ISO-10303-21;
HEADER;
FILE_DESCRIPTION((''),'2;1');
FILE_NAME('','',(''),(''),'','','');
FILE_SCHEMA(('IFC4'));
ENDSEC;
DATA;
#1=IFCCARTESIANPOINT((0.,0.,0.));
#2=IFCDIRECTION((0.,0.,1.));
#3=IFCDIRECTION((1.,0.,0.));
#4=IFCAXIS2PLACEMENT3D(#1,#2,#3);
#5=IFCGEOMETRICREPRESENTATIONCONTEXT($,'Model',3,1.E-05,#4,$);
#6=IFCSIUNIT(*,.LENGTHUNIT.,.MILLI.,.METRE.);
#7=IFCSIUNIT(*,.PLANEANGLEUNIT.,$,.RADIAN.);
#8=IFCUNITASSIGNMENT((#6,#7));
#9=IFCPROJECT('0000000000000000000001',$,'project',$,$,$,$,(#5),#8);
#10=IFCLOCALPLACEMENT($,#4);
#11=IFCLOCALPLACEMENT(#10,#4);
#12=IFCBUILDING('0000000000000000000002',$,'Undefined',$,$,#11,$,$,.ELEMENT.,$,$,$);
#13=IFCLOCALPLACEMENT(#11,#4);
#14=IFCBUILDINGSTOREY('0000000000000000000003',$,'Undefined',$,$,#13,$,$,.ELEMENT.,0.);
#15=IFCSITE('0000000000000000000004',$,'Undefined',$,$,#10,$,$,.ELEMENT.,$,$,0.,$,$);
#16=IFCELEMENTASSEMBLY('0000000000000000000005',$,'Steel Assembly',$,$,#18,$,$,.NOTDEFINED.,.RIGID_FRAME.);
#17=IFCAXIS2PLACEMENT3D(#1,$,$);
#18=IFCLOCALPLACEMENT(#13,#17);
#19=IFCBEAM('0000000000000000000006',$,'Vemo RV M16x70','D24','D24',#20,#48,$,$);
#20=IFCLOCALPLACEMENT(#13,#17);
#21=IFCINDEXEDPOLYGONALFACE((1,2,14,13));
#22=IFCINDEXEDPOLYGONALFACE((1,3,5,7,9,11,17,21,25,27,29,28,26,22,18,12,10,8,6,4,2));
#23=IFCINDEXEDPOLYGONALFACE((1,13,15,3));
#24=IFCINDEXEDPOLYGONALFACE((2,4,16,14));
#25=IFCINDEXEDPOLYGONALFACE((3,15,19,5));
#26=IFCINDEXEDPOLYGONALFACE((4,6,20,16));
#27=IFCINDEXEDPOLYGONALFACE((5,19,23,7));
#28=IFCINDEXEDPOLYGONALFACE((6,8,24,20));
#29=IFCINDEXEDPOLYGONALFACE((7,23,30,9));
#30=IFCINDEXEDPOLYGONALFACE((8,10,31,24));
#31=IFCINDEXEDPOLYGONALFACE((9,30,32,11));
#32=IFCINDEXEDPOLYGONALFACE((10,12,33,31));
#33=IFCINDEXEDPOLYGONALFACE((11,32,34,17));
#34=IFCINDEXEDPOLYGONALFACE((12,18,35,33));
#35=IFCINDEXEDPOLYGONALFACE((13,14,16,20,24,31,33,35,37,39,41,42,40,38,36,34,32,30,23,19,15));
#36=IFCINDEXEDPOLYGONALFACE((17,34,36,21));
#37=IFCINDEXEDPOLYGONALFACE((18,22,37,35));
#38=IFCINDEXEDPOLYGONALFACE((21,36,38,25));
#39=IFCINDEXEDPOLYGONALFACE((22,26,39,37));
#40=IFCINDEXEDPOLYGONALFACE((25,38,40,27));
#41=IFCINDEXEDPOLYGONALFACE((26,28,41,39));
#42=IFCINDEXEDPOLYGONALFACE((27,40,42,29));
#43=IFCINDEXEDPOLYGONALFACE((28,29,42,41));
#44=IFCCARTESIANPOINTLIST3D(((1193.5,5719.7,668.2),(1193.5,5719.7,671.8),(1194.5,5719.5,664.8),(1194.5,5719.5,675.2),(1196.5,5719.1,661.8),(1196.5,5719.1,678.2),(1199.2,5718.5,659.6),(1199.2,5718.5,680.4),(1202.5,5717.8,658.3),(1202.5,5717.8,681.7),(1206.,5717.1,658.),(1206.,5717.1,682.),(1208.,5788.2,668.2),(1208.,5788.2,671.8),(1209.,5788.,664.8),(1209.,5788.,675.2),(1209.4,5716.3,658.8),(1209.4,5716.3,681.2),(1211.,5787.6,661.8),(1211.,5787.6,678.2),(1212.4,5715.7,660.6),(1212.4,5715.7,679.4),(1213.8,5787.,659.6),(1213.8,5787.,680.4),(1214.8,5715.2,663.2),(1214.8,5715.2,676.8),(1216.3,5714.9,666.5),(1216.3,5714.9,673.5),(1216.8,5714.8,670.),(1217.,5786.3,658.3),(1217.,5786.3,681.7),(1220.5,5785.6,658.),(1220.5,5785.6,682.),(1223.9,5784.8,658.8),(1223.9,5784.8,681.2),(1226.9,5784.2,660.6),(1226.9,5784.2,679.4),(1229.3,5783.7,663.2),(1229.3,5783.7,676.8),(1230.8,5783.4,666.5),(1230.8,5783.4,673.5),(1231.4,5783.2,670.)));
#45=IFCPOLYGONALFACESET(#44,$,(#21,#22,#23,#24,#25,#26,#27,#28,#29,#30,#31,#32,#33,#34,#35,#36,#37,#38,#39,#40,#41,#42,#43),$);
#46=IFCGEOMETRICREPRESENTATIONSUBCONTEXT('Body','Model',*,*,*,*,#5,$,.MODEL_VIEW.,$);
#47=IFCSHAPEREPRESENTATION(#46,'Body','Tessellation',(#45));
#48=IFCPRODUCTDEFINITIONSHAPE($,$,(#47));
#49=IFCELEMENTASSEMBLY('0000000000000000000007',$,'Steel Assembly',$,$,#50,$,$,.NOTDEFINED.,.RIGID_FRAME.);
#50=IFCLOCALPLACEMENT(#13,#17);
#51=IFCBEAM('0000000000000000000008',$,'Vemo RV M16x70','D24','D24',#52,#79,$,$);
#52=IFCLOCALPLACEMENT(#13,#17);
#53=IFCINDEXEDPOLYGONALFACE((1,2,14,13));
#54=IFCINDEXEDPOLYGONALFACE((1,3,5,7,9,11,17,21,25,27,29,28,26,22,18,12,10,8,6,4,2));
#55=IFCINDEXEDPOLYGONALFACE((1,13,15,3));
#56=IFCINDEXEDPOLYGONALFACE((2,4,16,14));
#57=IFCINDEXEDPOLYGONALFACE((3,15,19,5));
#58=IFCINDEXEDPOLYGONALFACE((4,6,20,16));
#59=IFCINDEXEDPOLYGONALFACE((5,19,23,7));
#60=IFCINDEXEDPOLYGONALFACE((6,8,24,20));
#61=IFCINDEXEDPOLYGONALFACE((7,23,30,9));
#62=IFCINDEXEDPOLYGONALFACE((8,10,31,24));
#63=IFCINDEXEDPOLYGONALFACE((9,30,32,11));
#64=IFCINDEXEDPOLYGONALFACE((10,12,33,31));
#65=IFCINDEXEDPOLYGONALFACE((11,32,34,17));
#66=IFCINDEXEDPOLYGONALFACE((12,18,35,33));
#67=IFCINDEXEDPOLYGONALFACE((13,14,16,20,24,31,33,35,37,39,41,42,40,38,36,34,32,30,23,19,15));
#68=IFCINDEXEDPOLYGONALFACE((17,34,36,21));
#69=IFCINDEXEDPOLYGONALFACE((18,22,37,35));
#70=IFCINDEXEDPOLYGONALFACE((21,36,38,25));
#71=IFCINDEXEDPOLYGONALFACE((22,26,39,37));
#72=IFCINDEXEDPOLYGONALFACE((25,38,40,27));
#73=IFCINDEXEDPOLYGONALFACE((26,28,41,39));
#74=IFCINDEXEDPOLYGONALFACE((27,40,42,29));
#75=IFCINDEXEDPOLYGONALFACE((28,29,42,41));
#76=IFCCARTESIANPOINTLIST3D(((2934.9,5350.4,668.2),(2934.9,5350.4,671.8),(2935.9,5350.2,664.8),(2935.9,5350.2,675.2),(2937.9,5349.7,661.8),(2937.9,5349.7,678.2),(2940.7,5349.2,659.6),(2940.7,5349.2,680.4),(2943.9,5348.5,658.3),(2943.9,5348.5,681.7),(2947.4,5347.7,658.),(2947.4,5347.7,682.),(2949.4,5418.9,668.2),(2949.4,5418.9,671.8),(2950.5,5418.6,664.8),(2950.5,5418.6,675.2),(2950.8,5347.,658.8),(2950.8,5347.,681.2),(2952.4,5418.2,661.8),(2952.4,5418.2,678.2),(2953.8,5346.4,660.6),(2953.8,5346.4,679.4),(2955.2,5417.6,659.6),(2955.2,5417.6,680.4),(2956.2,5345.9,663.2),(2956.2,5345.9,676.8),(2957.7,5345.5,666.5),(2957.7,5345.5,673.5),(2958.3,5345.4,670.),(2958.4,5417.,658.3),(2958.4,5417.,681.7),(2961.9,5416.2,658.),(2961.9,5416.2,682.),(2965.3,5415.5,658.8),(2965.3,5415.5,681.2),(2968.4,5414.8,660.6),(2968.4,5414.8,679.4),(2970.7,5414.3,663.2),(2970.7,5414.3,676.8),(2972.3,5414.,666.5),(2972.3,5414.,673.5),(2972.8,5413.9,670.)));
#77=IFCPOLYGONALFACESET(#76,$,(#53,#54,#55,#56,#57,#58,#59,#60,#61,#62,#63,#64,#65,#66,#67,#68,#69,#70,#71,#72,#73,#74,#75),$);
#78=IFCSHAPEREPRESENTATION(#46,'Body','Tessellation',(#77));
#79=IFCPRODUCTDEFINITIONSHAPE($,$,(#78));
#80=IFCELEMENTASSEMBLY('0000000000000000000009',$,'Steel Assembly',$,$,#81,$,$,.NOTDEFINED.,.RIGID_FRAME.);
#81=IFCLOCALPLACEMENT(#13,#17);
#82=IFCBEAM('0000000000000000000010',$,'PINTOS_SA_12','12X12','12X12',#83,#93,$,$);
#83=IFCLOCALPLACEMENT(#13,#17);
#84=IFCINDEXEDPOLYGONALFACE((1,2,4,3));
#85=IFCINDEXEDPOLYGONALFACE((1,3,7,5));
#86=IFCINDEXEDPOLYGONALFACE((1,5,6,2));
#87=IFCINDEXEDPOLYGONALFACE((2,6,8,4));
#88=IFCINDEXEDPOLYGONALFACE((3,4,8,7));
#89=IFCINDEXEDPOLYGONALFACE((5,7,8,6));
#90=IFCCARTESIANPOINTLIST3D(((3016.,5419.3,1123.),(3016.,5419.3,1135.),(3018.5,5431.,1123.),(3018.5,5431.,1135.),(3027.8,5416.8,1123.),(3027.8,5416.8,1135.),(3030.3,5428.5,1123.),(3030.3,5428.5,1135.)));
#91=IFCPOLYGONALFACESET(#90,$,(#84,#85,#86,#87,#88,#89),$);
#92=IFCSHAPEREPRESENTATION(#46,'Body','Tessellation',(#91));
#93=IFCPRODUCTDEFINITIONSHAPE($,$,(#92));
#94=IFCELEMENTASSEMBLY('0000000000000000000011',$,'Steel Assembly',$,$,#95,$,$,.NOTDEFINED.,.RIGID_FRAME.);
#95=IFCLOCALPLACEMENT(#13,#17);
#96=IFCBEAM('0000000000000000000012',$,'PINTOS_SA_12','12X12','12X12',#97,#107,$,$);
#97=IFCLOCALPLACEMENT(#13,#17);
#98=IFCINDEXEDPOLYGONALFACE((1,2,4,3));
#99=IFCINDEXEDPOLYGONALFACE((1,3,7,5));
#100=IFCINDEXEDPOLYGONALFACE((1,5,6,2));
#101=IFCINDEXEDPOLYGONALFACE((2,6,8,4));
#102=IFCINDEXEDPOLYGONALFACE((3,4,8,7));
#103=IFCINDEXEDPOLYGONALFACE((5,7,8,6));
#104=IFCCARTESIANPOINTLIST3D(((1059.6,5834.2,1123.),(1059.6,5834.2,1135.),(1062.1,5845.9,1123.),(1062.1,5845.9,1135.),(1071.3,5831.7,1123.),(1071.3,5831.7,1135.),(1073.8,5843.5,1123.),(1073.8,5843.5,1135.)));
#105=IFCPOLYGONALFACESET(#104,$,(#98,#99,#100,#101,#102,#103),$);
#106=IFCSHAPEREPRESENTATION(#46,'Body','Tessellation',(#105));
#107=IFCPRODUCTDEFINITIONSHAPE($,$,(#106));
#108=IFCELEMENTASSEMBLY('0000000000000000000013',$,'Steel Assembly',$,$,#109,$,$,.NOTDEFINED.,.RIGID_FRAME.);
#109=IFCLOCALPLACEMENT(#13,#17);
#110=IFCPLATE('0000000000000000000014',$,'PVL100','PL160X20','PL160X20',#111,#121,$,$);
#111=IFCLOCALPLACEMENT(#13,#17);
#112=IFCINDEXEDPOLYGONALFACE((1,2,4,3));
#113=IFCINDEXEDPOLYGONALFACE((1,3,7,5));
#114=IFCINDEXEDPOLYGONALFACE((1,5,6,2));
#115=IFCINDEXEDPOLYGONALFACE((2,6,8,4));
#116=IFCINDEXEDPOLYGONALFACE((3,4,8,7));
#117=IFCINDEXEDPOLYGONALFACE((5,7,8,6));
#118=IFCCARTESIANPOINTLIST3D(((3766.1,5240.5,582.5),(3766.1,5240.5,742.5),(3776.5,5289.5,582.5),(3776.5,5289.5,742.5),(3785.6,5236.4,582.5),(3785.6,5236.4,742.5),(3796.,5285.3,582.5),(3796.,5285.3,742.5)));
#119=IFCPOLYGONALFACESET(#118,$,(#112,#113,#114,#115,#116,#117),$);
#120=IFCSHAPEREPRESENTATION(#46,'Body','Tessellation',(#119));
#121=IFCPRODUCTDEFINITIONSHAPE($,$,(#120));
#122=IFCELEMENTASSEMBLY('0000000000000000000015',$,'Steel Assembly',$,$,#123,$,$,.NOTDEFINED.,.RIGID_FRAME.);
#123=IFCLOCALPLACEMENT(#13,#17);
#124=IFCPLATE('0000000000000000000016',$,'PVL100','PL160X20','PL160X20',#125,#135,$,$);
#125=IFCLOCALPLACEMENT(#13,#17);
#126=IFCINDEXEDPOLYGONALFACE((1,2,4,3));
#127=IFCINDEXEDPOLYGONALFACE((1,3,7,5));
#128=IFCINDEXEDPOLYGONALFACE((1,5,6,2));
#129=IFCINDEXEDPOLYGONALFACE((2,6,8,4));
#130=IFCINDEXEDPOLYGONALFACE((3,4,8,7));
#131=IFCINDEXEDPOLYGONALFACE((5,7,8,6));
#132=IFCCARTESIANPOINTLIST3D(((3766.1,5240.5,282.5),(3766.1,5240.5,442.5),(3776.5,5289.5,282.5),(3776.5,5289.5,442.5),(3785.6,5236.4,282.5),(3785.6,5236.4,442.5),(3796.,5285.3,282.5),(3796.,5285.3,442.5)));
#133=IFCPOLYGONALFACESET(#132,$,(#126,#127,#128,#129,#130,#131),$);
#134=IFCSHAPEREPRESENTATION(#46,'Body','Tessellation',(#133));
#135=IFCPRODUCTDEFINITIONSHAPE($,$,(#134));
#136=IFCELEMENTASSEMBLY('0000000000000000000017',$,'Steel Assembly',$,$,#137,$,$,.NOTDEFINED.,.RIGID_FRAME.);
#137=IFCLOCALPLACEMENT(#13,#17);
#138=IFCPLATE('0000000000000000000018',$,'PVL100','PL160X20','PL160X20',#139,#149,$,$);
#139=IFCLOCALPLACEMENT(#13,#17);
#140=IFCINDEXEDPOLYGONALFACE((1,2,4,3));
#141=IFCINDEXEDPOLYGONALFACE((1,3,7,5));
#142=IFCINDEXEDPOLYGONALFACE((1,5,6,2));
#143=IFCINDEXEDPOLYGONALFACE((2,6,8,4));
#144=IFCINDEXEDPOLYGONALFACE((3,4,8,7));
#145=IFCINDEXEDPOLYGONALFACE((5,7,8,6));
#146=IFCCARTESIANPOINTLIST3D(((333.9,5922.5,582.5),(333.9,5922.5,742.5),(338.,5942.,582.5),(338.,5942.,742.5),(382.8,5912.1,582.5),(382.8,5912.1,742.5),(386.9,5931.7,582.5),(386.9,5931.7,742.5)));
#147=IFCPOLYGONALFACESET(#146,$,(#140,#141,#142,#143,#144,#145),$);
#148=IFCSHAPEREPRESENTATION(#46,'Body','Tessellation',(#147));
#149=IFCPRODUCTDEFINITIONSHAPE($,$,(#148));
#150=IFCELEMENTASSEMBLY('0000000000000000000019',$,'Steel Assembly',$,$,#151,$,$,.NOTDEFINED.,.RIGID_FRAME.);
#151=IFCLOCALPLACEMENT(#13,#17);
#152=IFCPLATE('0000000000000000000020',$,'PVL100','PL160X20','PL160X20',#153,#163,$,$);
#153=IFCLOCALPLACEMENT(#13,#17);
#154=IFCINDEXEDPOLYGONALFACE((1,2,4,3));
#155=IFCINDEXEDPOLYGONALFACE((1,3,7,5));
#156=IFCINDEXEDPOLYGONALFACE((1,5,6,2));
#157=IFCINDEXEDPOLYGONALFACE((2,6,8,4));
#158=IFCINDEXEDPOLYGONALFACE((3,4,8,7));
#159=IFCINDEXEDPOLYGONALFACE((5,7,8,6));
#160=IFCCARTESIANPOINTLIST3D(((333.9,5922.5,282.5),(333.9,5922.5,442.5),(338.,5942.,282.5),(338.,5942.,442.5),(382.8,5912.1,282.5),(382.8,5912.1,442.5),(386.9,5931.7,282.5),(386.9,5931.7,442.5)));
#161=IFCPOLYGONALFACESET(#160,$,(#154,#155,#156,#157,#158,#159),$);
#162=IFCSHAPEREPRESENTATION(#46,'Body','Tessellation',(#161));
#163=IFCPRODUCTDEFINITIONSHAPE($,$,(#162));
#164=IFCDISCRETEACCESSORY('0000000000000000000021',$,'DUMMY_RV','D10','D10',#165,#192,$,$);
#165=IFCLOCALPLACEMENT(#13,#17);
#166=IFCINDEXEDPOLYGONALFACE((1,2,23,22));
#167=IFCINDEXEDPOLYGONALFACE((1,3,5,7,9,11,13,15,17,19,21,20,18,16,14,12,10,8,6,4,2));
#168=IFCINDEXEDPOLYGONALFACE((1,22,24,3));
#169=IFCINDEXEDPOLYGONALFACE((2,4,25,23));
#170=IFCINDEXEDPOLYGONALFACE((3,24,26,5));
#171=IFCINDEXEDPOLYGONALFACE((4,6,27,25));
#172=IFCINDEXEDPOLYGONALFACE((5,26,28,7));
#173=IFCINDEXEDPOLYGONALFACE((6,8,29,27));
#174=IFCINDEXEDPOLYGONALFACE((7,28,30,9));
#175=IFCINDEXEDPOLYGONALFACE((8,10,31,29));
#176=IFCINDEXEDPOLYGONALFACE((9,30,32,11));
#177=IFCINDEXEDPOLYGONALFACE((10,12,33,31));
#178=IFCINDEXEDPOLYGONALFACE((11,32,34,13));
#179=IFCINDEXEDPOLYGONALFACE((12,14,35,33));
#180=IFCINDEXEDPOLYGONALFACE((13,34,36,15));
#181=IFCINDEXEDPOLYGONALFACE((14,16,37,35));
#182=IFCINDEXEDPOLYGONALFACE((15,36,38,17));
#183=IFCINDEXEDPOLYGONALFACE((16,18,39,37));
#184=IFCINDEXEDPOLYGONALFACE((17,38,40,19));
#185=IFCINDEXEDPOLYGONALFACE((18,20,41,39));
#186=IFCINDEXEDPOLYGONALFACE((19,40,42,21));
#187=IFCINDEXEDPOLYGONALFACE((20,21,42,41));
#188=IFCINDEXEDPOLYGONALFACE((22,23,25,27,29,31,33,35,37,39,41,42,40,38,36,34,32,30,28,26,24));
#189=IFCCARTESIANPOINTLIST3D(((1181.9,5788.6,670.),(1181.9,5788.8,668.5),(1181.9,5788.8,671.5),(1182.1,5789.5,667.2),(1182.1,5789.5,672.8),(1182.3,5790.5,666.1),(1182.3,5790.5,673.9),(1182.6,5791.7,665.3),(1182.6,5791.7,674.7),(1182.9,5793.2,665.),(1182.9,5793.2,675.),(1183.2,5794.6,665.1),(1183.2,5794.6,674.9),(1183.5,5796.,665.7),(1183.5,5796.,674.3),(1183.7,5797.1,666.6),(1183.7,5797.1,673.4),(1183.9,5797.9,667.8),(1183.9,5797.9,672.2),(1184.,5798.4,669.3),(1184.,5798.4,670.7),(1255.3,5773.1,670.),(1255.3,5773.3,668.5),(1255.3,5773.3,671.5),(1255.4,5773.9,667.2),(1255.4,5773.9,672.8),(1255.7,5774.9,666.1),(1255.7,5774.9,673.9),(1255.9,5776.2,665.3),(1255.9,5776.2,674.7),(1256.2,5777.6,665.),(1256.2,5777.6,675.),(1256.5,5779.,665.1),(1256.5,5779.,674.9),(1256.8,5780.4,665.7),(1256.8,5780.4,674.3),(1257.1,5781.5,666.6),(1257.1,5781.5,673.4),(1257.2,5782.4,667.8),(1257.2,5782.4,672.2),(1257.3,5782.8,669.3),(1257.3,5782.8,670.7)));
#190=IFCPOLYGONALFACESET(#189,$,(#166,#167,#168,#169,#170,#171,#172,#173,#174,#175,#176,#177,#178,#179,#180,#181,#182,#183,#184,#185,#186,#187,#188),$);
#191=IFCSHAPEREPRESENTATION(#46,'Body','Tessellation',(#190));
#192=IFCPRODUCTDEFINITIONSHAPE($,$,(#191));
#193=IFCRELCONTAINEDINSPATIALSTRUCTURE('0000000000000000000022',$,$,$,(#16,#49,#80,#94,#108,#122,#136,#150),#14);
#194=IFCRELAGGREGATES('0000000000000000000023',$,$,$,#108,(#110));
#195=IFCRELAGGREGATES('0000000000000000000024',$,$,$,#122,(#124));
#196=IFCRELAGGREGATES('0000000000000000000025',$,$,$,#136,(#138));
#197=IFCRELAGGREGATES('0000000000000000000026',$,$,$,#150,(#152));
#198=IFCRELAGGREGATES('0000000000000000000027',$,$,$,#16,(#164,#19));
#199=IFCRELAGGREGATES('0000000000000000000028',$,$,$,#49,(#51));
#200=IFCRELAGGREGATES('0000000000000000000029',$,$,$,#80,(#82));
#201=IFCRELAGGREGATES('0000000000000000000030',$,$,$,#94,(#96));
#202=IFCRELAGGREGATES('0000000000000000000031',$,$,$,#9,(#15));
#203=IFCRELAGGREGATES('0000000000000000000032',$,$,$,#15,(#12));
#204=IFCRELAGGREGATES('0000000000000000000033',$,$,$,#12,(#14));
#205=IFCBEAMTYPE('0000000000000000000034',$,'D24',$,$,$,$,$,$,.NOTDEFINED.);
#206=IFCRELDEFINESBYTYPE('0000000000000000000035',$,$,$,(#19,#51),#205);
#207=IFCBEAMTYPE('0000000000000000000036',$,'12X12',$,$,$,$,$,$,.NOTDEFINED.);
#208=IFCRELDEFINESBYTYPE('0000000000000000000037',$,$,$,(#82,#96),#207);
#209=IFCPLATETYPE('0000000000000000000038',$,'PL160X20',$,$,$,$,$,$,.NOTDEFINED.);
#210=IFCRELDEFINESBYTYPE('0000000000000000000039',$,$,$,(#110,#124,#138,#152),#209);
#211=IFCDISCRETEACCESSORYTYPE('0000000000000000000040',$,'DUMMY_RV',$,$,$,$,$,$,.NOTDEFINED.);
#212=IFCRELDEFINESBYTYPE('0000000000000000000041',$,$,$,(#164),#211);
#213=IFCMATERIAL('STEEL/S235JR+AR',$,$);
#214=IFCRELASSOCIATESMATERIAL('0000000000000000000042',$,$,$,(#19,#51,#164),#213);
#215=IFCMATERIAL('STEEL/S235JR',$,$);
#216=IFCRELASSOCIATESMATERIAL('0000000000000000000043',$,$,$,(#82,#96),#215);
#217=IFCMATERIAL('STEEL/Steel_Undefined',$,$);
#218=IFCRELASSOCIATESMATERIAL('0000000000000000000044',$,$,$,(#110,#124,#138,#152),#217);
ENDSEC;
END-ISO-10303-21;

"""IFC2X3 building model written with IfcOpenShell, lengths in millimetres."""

from ifc_helpers import new_model, si_unit, frame, origin_with_axes, origin_2d_with_axis, place, context, subcontext, project, spatial, polyline, rectangle, circle, outline, extrude, material, type_object, element, aggregate, save


model = new_model("IFC2X3")

# Units and contexts
model_context = context("Model", 3, precision=1e-05, world=origin_with_axes())
body_context = subcontext(model_context, "Body", "Model", "MODEL_VIEW")
ifc_project = project(units=[si_unit("LENGTHUNIT", "METRE", prefix="MILLI"), si_unit("PLANEANGLEUNIT", "RADIAN")], contexts=[model_context])

# Site, building, storey
site_placement = place(None, origin_with_axes())
site = spatial("IfcSite", under=ifc_project, at=site_placement, Name="Undefined", CompositionType="ELEMENT", RefElevation=0.0)
building_placement = place(site_placement, origin_with_axes())
building = spatial("IfcBuilding", under=site, at=building_placement, Name="Undefined", CompositionType="ELEMENT")
storey_placement = place(building_placement, origin_with_axes())
storey = spatial("IfcBuildingStorey", under=building, at=storey_placement, Name="Undefined", CompositionType="ELEMENT", Elevation=0.0)

# Element assemblies, beams
assembly_1_placement = place(storey_placement, origin_with_axes())
assembly_1 = element("IfcElementAssembly", 1, at=assembly_1_placement, inside=storey, Name="Steel Assembly", AssemblyPlace="NOTDEFINED", PredefinedType="RIGID_FRAME")
ifc_material_1 = material(Name="STEEL/S235JR+AR")
beam_type_1 = type_object("IfcBeamType", Name="D24", PredefinedType="NOTDEFINED")
beam_1_placement = place(assembly_1_placement, frame((1205.1, 5717.3, 670.0), z_axis=(0.0, 0.0, 1.0), x_axis=(0.207475, 0.97824, 0.0)))
beam_1 = element("IfcBeam", 2, at=beam_1_placement, type_object=beam_type_1, material=ifc_material_1, Name="Vemo RV M16x70", Description="D24", ObjectType="D24", context=body_context, shape_type="SweptSolid", body=[
    extrude(circle(Radius=12.0, at=origin_2d_with_axis()), frame((70.0, 0.0, 0.0), z_axis=(-1.0, 0.0, 0.0), x_axis=(0.0, -1.0, 0.0)), (0.0, 0.0, 1.0), 70.0),
])
assembly_2_placement = place(storey_placement, origin_with_axes())
assembly_2 = element("IfcElementAssembly", 3, at=assembly_2_placement, inside=storey, Name="Steel Assembly", AssemblyPlace="NOTDEFINED", PredefinedType="RIGID_FRAME")
beam_2_placement = place(assembly_2_placement, frame((2946.5, 5347.9, 670.0), z_axis=(0.0, 0.0, 1.0), x_axis=(0.207475, 0.97824, 0.0)))
beam_2 = element("IfcBeam", 4, at=beam_2_placement, type_object=beam_type_1, material=ifc_material_1, Name="Vemo RV M16x70", Description="D24", ObjectType="D24", context=body_context, shape_type="SweptSolid", body=[
    extrude(circle(Radius=12.0, at=origin_2d_with_axis()), frame((70.0, 0.0, 0.0), z_axis=(-1.0, 0.0, 0.0), x_axis=(0.0, -1.0, 0.0)), (0.0, 0.0, 1.0), 70.0),
])
assembly_3_placement = place(storey_placement, origin_with_axes())
assembly_3 = element("IfcElementAssembly", 5, at=assembly_3_placement, inside=storey, Name="Steel Assembly", AssemblyPlace="NOTDEFINED", PredefinedType="RIGID_FRAME")
ifc_material_2 = material(Name="STEEL/S235JR")
beam_type_2 = type_object("IfcBeamType", Name="12X12", PredefinedType="NOTDEFINED")
beam_3_placement = place(assembly_3_placement, frame((3029.0, 5422.6, 1129.0), z_axis=(0.0, 0.0, 1.0), x_axis=(-0.97824, 0.207475, 0.0)))
beam_3 = element("IfcBeam", 6, at=beam_3_placement, type_object=beam_type_2, material=ifc_material_2, Name="PINTOS_SA_12", Description="12X12", ObjectType="12X12", context=body_context, shape_type="SweptSolid", body=[
    extrude(rectangle(XDim=12.0, YDim=12.0, at=origin_2d_with_axis()), frame((12.0, 0.0, 0.0), z_axis=(-1.0, 0.0, 0.0), x_axis=(0.0, -1.0, 0.0)), (0.0, 0.0, 1.0), 12.0),
])
assembly_4_placement = place(storey_placement, origin_with_axes())
assembly_4 = element("IfcElementAssembly", 7, at=assembly_4_placement, inside=storey, Name="Steel Assembly", AssemblyPlace="NOTDEFINED", PredefinedType="RIGID_FRAME")
beam_4_placement = place(assembly_4_placement, frame((1060.8, 5840.1, 1129.0), z_axis=(0.0, 0.0, 1.0), x_axis=(0.97824, -0.207475, 0.0)))
beam_4 = element("IfcBeam", 8, at=beam_4_placement, type_object=beam_type_2, material=ifc_material_2, Name="PINTOS_SA_12", Description="12X12", ObjectType="12X12", context=body_context, shape_type="SweptSolid", body=[
    extrude(rectangle(XDim=12.0, YDim=12.0, at=origin_2d_with_axis()), frame((12.0, 0.0, 0.0), z_axis=(-1.0, 0.0, 0.0), x_axis=(0.0, -1.0, 0.0)), (0.0, 0.0, 1.0), 12.0),
])

# Element assemblies, plates
assembly_5_placement = place(storey_placement, origin_with_axes())
assembly_5 = element("IfcElementAssembly", 9, at=assembly_5_placement, inside=storey, Name="Steel Assembly", AssemblyPlace="NOTDEFINED", PredefinedType="RIGID_FRAME")
ifc_material_3 = material(Name="STEEL/Steel_Undefined")
plate_type = type_object("IfcPlateType", Name="PL160X20", PredefinedType="NOTDEFINED")
plate_1_placement = place(assembly_5_placement, frame((3796.0, 5285.3, 662.5), z_axis=(0.0, 0.0, -1.0), x_axis=(-0.207475, -0.97824, 0.0)))
plate_1 = element("IfcPlate", 10, at=plate_1_placement, type_object=plate_type, material=ifc_material_3, Name="PVL100", Description="PL160X20", ObjectType="PL160X20", context=body_context, shape_type="SweptSolid", body=[
    extrude(outline(polyline([(0.0, 0.0), (50.0, 0.0), (50.0, 20.0), (0.0, 20.0), (0.0, 0.0)])), frame((0.0, 0.0, -80.0), z_axis=(0.0, 0.0, 1.0), x_axis=(1.0, 0.0, 0.0)), (0.0, 0.0, 1.0), 160.0),
])
assembly_6_placement = place(storey_placement, origin_with_axes())
assembly_6 = element("IfcElementAssembly", 11, at=assembly_6_placement, inside=storey, Name="Steel Assembly", AssemblyPlace="NOTDEFINED", PredefinedType="RIGID_FRAME")
plate_2_placement = place(assembly_6_placement, frame((3796.0, 5285.3, 362.5), z_axis=(0.0, 0.0, -1.0), x_axis=(-0.207475, -0.97824, 0.0)))
plate_2 = element("IfcPlate", 12, at=plate_2_placement, type_object=plate_type, material=ifc_material_3, Name="PVL100", Description="PL160X20", ObjectType="PL160X20", context=body_context, shape_type="SweptSolid", body=[
    extrude(outline(polyline([(0.0, 0.0), (50.0, 0.0), (50.0, 20.0), (0.0, 20.0), (0.0, 0.0)])), frame((0.0, 0.0, -80.0), z_axis=(0.0, 0.0, 1.0), x_axis=(1.0, 0.0, 0.0)), (0.0, 0.0, 1.0), 160.0),
])
assembly_7_placement = place(storey_placement, origin_with_axes())
assembly_7 = element("IfcElementAssembly", 13, at=assembly_7_placement, inside=storey, Name="Steel Assembly", AssemblyPlace="NOTDEFINED", PredefinedType="RIGID_FRAME")
plate_3_placement = place(assembly_7_placement, frame((382.8, 5912.1, 662.5), z_axis=(0.0, 0.0, -1.0), x_axis=(-0.97824, 0.207475, 0.0)))
plate_3 = element("IfcPlate", 14, at=plate_3_placement, type_object=plate_type, material=ifc_material_3, Name="PVL100", Description="PL160X20", ObjectType="PL160X20", context=body_context, shape_type="SweptSolid", body=[
    extrude(outline(polyline([(0.0, 0.0), (50.0, 0.0), (50.0, 20.0), (0.0, 20.0), (0.0, 0.0)])), frame((0.0, 0.0, -80.0), z_axis=(0.0, 0.0, 1.0), x_axis=(1.0, 0.0, 0.0)), (0.0, 0.0, 1.0), 160.0),
])
assembly_8_placement = place(storey_placement, origin_with_axes())
assembly_8 = element("IfcElementAssembly", 15, at=assembly_8_placement, inside=storey, Name="Steel Assembly", AssemblyPlace="NOTDEFINED", PredefinedType="RIGID_FRAME")
plate_4_placement = place(assembly_8_placement, frame((382.8, 5912.1, 362.5), z_axis=(0.0, 0.0, -1.0), x_axis=(-0.97824, 0.207475, 0.0)))
plate_4 = element("IfcPlate", 16, at=plate_4_placement, type_object=plate_type, material=ifc_material_3, Name="PVL100", Description="PL160X20", ObjectType="PL160X20", context=body_context, shape_type="SweptSolid", body=[
    extrude(outline(polyline([(0.0, 0.0), (50.0, 0.0), (50.0, 20.0), (0.0, 20.0), (0.0, 0.0)])), frame((0.0, 0.0, -80.0), z_axis=(0.0, 0.0, 1.0), x_axis=(1.0, 0.0, 0.0)), (0.0, 0.0, 1.0), 160.0),
])

aggregate(assembly_5, [plate_1])
aggregate(assembly_6, [plate_2])
aggregate(assembly_7, [plate_3])
aggregate(assembly_8, [plate_4])

# Discrete accessory
discrete_accessory_type = type_object("IfcDiscreteAccessoryType", Name="DUMMY_RV")
discrete_accessory_1_placement = place(assembly_1_placement, frame((1182.9, 5793.5, 670.0), z_axis=(0.0, 0.0, 1.0), x_axis=(0.97824, -0.207475, 0.0)))
discrete_accessory_1 = element("IfcDiscreteAccessory", 17, at=discrete_accessory_1_placement, type_object=discrete_accessory_type, material=ifc_material_1, Name="DUMMY_RV", Description="D10", ObjectType="D10", context=body_context, shape_type="SweptSolid", body=[
    extrude(circle(Radius=5.0, at=origin_2d_with_axis()), frame((75.0, 0.0, 0.0), z_axis=(-1.0, 0.0, 0.0), x_axis=(0.0, -1.0, 0.0)), (0.0, 0.0, 1.0), 75.0),
])
aggregate(assembly_1, [discrete_accessory_1, beam_1])
aggregate(assembly_2, [beam_2])

aggregate(assembly_3, [beam_3])
aggregate(assembly_4, [beam_4])

save(model, "model.ifc")
